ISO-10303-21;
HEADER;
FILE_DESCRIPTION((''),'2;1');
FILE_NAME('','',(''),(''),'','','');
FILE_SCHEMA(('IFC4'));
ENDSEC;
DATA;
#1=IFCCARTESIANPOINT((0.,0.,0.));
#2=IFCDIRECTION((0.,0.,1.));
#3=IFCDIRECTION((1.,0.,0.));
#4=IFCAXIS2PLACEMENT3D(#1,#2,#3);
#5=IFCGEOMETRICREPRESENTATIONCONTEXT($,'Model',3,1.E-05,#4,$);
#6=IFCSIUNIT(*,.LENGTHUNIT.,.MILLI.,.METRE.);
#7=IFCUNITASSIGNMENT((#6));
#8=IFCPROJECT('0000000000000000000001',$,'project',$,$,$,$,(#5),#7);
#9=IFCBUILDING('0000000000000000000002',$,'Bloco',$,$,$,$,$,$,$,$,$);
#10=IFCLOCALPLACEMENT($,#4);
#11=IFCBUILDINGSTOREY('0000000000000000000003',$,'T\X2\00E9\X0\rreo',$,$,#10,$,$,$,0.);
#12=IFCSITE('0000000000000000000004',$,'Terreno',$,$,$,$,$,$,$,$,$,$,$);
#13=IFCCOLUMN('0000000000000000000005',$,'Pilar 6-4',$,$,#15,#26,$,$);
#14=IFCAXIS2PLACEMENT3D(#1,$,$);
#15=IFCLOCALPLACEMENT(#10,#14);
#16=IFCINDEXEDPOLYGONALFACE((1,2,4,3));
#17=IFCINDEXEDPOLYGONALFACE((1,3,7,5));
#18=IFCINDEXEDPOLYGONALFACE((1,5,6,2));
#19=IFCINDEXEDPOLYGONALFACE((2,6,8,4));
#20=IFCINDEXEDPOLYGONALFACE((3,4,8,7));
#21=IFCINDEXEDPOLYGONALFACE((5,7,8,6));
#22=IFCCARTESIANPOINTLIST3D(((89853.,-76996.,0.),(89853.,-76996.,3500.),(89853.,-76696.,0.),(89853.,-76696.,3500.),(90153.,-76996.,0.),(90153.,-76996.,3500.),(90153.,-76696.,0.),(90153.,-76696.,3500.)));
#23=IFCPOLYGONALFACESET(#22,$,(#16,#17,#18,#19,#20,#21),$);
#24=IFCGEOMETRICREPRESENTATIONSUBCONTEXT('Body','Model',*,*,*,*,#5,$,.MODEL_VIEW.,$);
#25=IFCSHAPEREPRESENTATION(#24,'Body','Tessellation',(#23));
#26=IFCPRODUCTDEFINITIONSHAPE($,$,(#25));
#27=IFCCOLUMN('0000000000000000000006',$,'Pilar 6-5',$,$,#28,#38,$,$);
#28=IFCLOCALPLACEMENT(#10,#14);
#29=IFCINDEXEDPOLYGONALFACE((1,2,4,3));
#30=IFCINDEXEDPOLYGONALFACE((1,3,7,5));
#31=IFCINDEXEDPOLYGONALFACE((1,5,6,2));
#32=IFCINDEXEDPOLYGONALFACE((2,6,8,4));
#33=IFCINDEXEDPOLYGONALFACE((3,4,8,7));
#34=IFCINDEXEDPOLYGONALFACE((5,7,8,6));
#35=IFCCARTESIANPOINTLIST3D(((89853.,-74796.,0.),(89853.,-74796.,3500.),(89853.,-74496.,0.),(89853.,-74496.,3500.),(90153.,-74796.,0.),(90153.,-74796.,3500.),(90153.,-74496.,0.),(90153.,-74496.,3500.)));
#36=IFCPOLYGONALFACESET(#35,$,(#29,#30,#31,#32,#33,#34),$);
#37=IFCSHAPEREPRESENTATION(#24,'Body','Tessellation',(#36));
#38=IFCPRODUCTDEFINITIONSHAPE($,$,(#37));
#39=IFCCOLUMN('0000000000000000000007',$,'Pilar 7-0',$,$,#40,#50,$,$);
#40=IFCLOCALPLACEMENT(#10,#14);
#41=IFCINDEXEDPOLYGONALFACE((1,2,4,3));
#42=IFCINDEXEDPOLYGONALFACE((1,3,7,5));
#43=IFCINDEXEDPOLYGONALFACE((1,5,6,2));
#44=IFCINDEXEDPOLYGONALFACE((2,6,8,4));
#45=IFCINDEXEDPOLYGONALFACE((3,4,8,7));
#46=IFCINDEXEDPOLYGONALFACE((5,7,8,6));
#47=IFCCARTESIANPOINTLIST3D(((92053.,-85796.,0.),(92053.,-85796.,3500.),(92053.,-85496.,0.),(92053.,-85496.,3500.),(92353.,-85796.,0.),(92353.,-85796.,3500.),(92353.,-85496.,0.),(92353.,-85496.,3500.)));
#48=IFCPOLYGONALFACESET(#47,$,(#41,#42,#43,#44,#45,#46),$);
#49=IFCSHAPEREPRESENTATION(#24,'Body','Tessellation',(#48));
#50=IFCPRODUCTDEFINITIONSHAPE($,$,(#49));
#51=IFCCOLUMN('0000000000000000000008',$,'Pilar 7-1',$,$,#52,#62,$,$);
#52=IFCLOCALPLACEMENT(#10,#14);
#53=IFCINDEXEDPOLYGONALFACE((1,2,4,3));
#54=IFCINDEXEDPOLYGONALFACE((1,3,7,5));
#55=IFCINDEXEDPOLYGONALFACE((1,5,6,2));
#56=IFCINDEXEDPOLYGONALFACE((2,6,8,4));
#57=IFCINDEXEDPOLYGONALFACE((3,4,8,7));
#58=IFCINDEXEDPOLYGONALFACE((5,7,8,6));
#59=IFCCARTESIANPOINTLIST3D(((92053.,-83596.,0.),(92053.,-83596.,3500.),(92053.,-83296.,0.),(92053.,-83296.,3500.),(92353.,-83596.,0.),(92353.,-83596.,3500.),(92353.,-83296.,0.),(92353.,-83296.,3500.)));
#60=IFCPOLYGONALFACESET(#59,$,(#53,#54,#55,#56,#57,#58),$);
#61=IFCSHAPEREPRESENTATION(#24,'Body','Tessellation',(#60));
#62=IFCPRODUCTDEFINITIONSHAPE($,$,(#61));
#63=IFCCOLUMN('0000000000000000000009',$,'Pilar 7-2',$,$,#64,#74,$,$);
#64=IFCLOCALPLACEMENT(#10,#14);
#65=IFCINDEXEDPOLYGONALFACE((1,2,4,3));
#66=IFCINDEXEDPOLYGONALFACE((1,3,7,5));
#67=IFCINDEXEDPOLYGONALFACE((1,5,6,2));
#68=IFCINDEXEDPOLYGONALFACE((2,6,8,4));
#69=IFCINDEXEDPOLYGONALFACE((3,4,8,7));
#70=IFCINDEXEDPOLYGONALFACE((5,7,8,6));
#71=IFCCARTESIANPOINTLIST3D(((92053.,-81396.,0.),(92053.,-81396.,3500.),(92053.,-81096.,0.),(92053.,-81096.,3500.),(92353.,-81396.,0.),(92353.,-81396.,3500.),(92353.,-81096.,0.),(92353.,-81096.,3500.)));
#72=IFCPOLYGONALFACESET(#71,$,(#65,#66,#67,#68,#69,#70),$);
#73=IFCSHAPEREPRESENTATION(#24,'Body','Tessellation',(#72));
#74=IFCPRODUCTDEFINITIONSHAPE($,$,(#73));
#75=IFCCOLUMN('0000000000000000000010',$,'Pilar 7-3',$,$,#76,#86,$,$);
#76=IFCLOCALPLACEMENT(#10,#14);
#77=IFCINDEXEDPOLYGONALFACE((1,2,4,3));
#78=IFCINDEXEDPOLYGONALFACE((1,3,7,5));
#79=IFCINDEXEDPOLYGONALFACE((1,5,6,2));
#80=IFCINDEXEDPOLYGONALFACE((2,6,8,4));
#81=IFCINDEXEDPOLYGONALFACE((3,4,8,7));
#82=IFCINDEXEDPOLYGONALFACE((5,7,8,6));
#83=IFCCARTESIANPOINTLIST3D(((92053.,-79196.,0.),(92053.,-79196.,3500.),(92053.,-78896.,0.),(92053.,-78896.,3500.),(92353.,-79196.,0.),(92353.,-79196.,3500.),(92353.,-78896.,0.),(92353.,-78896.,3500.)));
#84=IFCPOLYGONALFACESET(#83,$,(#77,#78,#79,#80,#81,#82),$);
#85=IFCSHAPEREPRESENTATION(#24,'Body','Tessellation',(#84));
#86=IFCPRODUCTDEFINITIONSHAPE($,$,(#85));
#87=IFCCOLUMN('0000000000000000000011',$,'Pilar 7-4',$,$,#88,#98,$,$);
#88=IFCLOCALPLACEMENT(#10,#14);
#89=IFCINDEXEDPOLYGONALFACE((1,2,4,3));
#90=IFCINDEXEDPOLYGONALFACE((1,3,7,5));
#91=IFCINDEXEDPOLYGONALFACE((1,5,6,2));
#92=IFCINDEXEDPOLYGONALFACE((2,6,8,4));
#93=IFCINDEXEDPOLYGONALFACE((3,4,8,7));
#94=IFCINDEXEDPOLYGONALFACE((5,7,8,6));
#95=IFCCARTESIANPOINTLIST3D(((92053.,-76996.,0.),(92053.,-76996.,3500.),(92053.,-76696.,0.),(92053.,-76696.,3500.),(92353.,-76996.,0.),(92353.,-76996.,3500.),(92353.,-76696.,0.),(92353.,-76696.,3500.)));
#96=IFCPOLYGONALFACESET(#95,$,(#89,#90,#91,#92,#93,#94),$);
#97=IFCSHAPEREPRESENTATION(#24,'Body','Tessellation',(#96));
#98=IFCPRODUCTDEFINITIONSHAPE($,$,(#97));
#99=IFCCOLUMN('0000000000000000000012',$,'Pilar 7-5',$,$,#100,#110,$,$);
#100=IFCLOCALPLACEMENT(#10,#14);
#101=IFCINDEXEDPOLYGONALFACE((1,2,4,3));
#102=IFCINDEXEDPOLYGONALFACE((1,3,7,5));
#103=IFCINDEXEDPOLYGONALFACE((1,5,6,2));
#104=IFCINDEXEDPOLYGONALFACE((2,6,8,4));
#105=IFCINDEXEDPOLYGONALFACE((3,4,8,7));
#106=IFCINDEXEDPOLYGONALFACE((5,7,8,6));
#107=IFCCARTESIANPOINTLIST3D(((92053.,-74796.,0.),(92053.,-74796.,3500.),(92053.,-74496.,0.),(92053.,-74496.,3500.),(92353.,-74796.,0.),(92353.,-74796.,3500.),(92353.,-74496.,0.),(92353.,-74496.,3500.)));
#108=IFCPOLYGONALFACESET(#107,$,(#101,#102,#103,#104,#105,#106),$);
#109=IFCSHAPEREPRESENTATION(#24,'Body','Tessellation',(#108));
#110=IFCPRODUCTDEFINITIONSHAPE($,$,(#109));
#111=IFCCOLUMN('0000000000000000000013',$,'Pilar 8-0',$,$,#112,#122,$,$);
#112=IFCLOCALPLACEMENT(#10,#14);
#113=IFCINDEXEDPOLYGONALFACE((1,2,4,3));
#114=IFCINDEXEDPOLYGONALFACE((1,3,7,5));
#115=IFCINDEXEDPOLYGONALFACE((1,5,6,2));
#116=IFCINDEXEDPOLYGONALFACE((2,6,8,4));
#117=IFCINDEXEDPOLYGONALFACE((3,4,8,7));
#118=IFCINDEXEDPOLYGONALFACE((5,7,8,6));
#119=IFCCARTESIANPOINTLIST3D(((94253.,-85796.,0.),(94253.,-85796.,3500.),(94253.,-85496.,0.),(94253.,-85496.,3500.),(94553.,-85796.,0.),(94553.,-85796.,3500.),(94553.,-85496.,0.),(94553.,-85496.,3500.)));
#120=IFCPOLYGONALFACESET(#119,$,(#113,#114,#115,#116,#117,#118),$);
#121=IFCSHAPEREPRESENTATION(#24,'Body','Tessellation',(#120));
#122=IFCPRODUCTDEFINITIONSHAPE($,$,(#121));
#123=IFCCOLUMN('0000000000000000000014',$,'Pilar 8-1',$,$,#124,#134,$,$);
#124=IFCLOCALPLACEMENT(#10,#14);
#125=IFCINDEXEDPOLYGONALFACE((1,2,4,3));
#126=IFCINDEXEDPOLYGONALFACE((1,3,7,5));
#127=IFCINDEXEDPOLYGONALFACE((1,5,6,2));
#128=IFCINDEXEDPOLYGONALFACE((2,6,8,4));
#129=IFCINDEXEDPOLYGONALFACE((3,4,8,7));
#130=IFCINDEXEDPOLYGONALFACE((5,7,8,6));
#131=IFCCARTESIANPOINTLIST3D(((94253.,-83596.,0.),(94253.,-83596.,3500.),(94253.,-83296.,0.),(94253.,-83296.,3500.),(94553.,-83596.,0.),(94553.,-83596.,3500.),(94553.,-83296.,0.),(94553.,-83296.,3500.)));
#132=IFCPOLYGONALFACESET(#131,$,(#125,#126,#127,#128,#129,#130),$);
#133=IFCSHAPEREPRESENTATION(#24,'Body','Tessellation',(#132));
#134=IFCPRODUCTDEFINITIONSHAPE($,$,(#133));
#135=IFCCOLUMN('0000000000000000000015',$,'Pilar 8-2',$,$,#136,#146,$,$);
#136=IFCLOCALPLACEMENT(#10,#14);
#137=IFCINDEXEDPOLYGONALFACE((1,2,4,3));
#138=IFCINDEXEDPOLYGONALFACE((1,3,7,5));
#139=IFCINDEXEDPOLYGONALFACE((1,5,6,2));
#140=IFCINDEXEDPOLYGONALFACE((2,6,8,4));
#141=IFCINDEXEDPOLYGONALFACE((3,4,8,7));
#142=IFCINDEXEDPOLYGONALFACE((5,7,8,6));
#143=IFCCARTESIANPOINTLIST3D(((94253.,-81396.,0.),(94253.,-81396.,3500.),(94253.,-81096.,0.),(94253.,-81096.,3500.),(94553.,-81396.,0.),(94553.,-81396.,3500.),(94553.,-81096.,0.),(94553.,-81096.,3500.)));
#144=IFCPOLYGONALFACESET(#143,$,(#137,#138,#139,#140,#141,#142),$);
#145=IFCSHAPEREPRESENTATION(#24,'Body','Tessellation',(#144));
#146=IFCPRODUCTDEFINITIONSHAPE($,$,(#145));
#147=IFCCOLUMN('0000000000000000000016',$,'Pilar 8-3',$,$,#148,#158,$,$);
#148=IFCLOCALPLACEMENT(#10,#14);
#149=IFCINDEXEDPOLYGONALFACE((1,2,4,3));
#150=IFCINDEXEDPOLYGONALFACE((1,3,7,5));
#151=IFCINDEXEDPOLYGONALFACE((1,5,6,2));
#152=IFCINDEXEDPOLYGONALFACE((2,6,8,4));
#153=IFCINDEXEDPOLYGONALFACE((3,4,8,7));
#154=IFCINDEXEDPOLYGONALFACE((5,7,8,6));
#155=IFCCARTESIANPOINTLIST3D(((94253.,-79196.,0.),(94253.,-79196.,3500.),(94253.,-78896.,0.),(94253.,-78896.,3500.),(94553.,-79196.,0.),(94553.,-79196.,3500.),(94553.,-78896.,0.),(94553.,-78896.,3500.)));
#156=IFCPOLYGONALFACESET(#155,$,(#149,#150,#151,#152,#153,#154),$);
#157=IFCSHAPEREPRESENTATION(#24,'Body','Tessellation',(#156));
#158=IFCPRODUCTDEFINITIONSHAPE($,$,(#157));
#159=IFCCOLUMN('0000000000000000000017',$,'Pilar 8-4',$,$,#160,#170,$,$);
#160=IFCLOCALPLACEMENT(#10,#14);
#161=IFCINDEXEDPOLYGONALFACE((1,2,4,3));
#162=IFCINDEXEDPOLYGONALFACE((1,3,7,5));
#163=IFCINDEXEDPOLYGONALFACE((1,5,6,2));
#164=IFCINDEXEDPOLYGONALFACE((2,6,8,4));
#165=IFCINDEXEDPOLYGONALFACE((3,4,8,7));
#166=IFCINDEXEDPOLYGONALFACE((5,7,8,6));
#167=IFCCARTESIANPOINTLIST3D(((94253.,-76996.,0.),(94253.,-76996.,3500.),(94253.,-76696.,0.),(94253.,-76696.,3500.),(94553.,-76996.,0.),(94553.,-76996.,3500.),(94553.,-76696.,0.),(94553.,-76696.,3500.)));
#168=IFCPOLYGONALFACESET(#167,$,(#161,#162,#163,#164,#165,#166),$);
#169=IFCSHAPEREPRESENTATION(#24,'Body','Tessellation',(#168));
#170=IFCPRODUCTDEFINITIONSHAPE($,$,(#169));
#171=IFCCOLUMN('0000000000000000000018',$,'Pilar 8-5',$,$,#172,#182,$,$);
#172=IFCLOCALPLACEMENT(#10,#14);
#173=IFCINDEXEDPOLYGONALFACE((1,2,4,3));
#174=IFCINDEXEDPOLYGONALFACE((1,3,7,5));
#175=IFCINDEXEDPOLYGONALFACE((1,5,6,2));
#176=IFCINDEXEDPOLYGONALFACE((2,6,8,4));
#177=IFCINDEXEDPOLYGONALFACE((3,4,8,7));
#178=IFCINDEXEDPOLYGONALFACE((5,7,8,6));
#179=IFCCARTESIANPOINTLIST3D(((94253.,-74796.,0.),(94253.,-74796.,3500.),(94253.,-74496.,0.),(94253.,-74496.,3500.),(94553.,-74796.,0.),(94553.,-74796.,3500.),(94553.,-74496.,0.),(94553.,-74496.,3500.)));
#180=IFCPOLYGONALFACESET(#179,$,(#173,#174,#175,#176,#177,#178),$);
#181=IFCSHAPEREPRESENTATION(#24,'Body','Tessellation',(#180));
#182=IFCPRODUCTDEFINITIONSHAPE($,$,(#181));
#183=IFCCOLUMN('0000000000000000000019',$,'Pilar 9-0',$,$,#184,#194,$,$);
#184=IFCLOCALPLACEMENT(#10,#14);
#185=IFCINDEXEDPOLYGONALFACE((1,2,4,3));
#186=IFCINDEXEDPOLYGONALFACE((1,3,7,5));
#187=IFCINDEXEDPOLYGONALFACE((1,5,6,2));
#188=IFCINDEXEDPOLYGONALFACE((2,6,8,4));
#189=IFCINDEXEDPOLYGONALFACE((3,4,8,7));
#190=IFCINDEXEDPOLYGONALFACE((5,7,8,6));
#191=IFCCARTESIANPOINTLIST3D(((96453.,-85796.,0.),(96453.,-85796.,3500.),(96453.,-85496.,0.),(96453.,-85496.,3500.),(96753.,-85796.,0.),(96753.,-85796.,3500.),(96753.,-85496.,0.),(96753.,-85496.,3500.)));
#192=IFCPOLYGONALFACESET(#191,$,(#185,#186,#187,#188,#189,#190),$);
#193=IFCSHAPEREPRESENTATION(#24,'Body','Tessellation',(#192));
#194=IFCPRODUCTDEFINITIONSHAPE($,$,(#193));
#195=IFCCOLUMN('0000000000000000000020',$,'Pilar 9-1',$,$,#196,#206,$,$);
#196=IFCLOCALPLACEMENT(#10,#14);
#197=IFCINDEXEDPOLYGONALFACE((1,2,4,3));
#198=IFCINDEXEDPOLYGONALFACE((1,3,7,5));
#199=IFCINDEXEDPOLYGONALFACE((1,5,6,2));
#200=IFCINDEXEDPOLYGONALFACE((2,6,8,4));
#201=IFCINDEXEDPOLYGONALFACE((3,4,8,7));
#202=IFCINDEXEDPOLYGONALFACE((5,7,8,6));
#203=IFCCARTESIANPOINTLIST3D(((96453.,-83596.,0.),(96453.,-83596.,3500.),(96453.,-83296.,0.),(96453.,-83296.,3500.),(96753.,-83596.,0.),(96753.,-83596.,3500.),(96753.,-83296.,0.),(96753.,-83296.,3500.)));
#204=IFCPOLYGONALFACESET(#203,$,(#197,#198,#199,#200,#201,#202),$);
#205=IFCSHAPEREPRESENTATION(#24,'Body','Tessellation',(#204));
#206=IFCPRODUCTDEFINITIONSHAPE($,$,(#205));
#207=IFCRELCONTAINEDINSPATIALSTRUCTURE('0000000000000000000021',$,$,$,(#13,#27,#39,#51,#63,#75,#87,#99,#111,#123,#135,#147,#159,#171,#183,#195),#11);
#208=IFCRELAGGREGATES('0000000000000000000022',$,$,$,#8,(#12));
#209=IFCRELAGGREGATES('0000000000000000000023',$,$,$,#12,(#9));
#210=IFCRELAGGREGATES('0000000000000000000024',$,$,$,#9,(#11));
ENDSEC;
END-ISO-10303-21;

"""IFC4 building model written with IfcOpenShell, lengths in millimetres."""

from ifc_helpers import new_model, si_unit, origin, origin_with_axes, place, context, subcontext, project, spatial, polyline, outline, extrude, element, save


model = new_model("IFC4")

# Units and contexts
model_context = context("Model", 3, precision=1e-05, world=origin_with_axes())
body_context = subcontext(model_context, "Body", "Model", "MODEL_VIEW")
ifc_project = project(units=[si_unit("LENGTHUNIT", "METRE", prefix="MILLI")], contexts=[model_context])

# Site, building, storey
site = spatial("IfcSite", under=ifc_project, Name="Terreno")
building = spatial("IfcBuilding", under=site, Name="Bloco")
storey_placement = place(None, origin_with_axes())
storey = spatial("IfcBuildingStorey", under=building, at=storey_placement, Name="Térreo", Elevation=0.0)

# Columns
column_1_placement = place(storey_placement, origin_with_axes())
element("IfcColumn", 1, at=column_1_placement, inside=storey, Name="Pilar 6-4", context=body_context, shape_type="SweptSolid", body=[
    extrude(outline(polyline([(89853.0, -76996.0), (90153.0, -76996.0), (90153.0, -76696.0), (89853.0, -76696.0), (89853.0, -76996.0)])), origin(), (0.0, 0.0, 1.0), 3500.0),
])
column_2_placement = place(storey_placement, origin_with_axes())
element("IfcColumn", 2, at=column_2_placement, inside=storey, Name="Pilar 6-5", context=body_context, shape_type="SweptSolid", body=[
    extrude(outline(polyline([(89853.0, -74796.0), (90153.0, -74796.0), (90153.0, -74496.0), (89853.0, -74496.0), (89853.0, -74796.0)])), origin(), (0.0, 0.0, 1.0), 3500.0),
])
column_3_placement = place(storey_placement, origin_with_axes())
element("IfcColumn", 3, at=column_3_placement, inside=storey, Name="Pilar 7-0", context=body_context, shape_type="SweptSolid", body=[
    extrude(outline(polyline([(92053.0, -85796.0), (92353.0, -85796.0), (92353.0, -85496.0), (92053.0, -85496.0), (92053.0, -85796.0)])), origin(), (0.0, 0.0, 1.0), 3500.0),
])
column_4_placement = place(storey_placement, origin_with_axes())
element("IfcColumn", 4, at=column_4_placement, inside=storey, Name="Pilar 7-1", context=body_context, shape_type="SweptSolid", body=[
    extrude(outline(polyline([(92053.0, -83596.0), (92353.0, -83596.0), (92353.0, -83296.0), (92053.0, -83296.0), (92053.0, -83596.0)])), origin(), (0.0, 0.0, 1.0), 3500.0),
])
column_5_placement = place(storey_placement, origin_with_axes())
element("IfcColumn", 5, at=column_5_placement, inside=storey, Name="Pilar 7-2", context=body_context, shape_type="SweptSolid", body=[
    extrude(outline(polyline([(92053.0, -81396.0), (92353.0, -81396.0), (92353.0, -81096.0), (92053.0, -81096.0), (92053.0, -81396.0)])), origin(), (0.0, 0.0, 1.0), 3500.0),
])
column_6_placement = place(storey_placement, origin_with_axes())
element("IfcColumn", 6, at=column_6_placement, inside=storey, Name="Pilar 7-3", context=body_context, shape_type="SweptSolid", body=[
    extrude(outline(polyline([(92053.0, -79196.0), (92353.0, -79196.0), (92353.0, -78896.0), (92053.0, -78896.0), (92053.0, -79196.0)])), origin(), (0.0, 0.0, 1.0), 3500.0),
])
column_7_placement = place(storey_placement, origin_with_axes())
element("IfcColumn", 7, at=column_7_placement, inside=storey, Name="Pilar 7-4", context=body_context, shape_type="SweptSolid", body=[
    extrude(outline(polyline([(92053.0, -76996.0), (92353.0, -76996.0), (92353.0, -76696.0), (92053.0, -76696.0), (92053.0, -76996.0)])), origin(), (0.0, 0.0, 1.0), 3500.0),
])
column_8_placement = place(storey_placement, origin_with_axes())
element("IfcColumn", 8, at=column_8_placement, inside=storey, Name="Pilar 7-5", context=body_context, shape_type="SweptSolid", body=[
    extrude(outline(polyline([(92053.0, -74796.0), (92353.0, -74796.0), (92353.0, -74496.0), (92053.0, -74496.0), (92053.0, -74796.0)])), origin(), (0.0, 0.0, 1.0), 3500.0),
])
column_9_placement = place(storey_placement, origin_with_axes())
element("IfcColumn", 9, at=column_9_placement, inside=storey, Name="Pilar 8-0", context=body_context, shape_type="SweptSolid", body=[
    extrude(outline(polyline([(94253.0, -85796.0), (94553.0, -85796.0), (94553.0, -85496.0), (94253.0, -85496.0), (94253.0, -85796.0)])), origin(), (0.0, 0.0, 1.0), 3500.0),
])
column_10_placement = place(storey_placement, origin_with_axes())
element("IfcColumn", 10, at=column_10_placement, inside=storey, Name="Pilar 8-1", context=body_context, shape_type="SweptSolid", body=[
    extrude(outline(polyline([(94253.0, -83596.0), (94553.0, -83596.0), (94553.0, -83296.0), (94253.0, -83296.0), (94253.0, -83596.0)])), origin(), (0.0, 0.0, 1.0), 3500.0),
])
column_11_placement = place(storey_placement, origin_with_axes())
element("IfcColumn", 11, at=column_11_placement, inside=storey, Name="Pilar 8-2", context=body_context, shape_type="SweptSolid", body=[
    extrude(outline(polyline([(94253.0, -81396.0), (94553.0, -81396.0), (94553.0, -81096.0), (94253.0, -81096.0), (94253.0, -81396.0)])), origin(), (0.0, 0.0, 1.0), 3500.0),
])
column_12_placement = place(storey_placement, origin_with_axes())
element("IfcColumn", 12, at=column_12_placement, inside=storey, Name="Pilar 8-3", context=body_context, shape_type="SweptSolid", body=[
    extrude(outline(polyline([(94253.0, -79196.0), (94553.0, -79196.0), (94553.0, -78896.0), (94253.0, -78896.0), (94253.0, -79196.0)])), origin(), (0.0, 0.0, 1.0), 3500.0),
])
column_13_placement = place(storey_placement, origin_with_axes())
element("IfcColumn", 13, at=column_13_placement, inside=storey, Name="Pilar 8-4", context=body_context, shape_type="SweptSolid", body=[
    extrude(outline(polyline([(94253.0, -76996.0), (94553.0, -76996.0), (94553.0, -76696.0), (94253.0, -76696.0), (94253.0, -76996.0)])), origin(), (0.0, 0.0, 1.0), 3500.0),
])
column_14_placement = place(storey_placement, origin_with_axes())
element("IfcColumn", 14, at=column_14_placement, inside=storey, Name="Pilar 8-5", context=body_context, shape_type="SweptSolid", body=[
    extrude(outline(polyline([(94253.0, -74796.0), (94553.0, -74796.0), (94553.0, -74496.0), (94253.0, -74496.0), (94253.0, -74796.0)])), origin(), (0.0, 0.0, 1.0), 3500.0),
])
column_15_placement = place(storey_placement, origin_with_axes())
element("IfcColumn", 15, at=column_15_placement, inside=storey, Name="Pilar 9-0", context=body_context, shape_type="SweptSolid", body=[
    extrude(outline(polyline([(96453.0, -85796.0), (96753.0, -85796.0), (96753.0, -85496.0), (96453.0, -85496.0), (96453.0, -85796.0)])), origin(), (0.0, 0.0, 1.0), 3500.0),
])
column_16_placement = place(storey_placement, origin_with_axes())
element("IfcColumn", 16, at=column_16_placement, inside=storey, Name="Pilar 9-1", context=body_context, shape_type="SweptSolid", body=[
    extrude(outline(polyline([(96453.0, -83596.0), (96753.0, -83596.0), (96753.0, -83296.0), (96453.0, -83296.0), (96453.0, -83596.0)])), origin(), (0.0, 0.0, 1.0), 3500.0),
])

save(model, "model.ifc")
